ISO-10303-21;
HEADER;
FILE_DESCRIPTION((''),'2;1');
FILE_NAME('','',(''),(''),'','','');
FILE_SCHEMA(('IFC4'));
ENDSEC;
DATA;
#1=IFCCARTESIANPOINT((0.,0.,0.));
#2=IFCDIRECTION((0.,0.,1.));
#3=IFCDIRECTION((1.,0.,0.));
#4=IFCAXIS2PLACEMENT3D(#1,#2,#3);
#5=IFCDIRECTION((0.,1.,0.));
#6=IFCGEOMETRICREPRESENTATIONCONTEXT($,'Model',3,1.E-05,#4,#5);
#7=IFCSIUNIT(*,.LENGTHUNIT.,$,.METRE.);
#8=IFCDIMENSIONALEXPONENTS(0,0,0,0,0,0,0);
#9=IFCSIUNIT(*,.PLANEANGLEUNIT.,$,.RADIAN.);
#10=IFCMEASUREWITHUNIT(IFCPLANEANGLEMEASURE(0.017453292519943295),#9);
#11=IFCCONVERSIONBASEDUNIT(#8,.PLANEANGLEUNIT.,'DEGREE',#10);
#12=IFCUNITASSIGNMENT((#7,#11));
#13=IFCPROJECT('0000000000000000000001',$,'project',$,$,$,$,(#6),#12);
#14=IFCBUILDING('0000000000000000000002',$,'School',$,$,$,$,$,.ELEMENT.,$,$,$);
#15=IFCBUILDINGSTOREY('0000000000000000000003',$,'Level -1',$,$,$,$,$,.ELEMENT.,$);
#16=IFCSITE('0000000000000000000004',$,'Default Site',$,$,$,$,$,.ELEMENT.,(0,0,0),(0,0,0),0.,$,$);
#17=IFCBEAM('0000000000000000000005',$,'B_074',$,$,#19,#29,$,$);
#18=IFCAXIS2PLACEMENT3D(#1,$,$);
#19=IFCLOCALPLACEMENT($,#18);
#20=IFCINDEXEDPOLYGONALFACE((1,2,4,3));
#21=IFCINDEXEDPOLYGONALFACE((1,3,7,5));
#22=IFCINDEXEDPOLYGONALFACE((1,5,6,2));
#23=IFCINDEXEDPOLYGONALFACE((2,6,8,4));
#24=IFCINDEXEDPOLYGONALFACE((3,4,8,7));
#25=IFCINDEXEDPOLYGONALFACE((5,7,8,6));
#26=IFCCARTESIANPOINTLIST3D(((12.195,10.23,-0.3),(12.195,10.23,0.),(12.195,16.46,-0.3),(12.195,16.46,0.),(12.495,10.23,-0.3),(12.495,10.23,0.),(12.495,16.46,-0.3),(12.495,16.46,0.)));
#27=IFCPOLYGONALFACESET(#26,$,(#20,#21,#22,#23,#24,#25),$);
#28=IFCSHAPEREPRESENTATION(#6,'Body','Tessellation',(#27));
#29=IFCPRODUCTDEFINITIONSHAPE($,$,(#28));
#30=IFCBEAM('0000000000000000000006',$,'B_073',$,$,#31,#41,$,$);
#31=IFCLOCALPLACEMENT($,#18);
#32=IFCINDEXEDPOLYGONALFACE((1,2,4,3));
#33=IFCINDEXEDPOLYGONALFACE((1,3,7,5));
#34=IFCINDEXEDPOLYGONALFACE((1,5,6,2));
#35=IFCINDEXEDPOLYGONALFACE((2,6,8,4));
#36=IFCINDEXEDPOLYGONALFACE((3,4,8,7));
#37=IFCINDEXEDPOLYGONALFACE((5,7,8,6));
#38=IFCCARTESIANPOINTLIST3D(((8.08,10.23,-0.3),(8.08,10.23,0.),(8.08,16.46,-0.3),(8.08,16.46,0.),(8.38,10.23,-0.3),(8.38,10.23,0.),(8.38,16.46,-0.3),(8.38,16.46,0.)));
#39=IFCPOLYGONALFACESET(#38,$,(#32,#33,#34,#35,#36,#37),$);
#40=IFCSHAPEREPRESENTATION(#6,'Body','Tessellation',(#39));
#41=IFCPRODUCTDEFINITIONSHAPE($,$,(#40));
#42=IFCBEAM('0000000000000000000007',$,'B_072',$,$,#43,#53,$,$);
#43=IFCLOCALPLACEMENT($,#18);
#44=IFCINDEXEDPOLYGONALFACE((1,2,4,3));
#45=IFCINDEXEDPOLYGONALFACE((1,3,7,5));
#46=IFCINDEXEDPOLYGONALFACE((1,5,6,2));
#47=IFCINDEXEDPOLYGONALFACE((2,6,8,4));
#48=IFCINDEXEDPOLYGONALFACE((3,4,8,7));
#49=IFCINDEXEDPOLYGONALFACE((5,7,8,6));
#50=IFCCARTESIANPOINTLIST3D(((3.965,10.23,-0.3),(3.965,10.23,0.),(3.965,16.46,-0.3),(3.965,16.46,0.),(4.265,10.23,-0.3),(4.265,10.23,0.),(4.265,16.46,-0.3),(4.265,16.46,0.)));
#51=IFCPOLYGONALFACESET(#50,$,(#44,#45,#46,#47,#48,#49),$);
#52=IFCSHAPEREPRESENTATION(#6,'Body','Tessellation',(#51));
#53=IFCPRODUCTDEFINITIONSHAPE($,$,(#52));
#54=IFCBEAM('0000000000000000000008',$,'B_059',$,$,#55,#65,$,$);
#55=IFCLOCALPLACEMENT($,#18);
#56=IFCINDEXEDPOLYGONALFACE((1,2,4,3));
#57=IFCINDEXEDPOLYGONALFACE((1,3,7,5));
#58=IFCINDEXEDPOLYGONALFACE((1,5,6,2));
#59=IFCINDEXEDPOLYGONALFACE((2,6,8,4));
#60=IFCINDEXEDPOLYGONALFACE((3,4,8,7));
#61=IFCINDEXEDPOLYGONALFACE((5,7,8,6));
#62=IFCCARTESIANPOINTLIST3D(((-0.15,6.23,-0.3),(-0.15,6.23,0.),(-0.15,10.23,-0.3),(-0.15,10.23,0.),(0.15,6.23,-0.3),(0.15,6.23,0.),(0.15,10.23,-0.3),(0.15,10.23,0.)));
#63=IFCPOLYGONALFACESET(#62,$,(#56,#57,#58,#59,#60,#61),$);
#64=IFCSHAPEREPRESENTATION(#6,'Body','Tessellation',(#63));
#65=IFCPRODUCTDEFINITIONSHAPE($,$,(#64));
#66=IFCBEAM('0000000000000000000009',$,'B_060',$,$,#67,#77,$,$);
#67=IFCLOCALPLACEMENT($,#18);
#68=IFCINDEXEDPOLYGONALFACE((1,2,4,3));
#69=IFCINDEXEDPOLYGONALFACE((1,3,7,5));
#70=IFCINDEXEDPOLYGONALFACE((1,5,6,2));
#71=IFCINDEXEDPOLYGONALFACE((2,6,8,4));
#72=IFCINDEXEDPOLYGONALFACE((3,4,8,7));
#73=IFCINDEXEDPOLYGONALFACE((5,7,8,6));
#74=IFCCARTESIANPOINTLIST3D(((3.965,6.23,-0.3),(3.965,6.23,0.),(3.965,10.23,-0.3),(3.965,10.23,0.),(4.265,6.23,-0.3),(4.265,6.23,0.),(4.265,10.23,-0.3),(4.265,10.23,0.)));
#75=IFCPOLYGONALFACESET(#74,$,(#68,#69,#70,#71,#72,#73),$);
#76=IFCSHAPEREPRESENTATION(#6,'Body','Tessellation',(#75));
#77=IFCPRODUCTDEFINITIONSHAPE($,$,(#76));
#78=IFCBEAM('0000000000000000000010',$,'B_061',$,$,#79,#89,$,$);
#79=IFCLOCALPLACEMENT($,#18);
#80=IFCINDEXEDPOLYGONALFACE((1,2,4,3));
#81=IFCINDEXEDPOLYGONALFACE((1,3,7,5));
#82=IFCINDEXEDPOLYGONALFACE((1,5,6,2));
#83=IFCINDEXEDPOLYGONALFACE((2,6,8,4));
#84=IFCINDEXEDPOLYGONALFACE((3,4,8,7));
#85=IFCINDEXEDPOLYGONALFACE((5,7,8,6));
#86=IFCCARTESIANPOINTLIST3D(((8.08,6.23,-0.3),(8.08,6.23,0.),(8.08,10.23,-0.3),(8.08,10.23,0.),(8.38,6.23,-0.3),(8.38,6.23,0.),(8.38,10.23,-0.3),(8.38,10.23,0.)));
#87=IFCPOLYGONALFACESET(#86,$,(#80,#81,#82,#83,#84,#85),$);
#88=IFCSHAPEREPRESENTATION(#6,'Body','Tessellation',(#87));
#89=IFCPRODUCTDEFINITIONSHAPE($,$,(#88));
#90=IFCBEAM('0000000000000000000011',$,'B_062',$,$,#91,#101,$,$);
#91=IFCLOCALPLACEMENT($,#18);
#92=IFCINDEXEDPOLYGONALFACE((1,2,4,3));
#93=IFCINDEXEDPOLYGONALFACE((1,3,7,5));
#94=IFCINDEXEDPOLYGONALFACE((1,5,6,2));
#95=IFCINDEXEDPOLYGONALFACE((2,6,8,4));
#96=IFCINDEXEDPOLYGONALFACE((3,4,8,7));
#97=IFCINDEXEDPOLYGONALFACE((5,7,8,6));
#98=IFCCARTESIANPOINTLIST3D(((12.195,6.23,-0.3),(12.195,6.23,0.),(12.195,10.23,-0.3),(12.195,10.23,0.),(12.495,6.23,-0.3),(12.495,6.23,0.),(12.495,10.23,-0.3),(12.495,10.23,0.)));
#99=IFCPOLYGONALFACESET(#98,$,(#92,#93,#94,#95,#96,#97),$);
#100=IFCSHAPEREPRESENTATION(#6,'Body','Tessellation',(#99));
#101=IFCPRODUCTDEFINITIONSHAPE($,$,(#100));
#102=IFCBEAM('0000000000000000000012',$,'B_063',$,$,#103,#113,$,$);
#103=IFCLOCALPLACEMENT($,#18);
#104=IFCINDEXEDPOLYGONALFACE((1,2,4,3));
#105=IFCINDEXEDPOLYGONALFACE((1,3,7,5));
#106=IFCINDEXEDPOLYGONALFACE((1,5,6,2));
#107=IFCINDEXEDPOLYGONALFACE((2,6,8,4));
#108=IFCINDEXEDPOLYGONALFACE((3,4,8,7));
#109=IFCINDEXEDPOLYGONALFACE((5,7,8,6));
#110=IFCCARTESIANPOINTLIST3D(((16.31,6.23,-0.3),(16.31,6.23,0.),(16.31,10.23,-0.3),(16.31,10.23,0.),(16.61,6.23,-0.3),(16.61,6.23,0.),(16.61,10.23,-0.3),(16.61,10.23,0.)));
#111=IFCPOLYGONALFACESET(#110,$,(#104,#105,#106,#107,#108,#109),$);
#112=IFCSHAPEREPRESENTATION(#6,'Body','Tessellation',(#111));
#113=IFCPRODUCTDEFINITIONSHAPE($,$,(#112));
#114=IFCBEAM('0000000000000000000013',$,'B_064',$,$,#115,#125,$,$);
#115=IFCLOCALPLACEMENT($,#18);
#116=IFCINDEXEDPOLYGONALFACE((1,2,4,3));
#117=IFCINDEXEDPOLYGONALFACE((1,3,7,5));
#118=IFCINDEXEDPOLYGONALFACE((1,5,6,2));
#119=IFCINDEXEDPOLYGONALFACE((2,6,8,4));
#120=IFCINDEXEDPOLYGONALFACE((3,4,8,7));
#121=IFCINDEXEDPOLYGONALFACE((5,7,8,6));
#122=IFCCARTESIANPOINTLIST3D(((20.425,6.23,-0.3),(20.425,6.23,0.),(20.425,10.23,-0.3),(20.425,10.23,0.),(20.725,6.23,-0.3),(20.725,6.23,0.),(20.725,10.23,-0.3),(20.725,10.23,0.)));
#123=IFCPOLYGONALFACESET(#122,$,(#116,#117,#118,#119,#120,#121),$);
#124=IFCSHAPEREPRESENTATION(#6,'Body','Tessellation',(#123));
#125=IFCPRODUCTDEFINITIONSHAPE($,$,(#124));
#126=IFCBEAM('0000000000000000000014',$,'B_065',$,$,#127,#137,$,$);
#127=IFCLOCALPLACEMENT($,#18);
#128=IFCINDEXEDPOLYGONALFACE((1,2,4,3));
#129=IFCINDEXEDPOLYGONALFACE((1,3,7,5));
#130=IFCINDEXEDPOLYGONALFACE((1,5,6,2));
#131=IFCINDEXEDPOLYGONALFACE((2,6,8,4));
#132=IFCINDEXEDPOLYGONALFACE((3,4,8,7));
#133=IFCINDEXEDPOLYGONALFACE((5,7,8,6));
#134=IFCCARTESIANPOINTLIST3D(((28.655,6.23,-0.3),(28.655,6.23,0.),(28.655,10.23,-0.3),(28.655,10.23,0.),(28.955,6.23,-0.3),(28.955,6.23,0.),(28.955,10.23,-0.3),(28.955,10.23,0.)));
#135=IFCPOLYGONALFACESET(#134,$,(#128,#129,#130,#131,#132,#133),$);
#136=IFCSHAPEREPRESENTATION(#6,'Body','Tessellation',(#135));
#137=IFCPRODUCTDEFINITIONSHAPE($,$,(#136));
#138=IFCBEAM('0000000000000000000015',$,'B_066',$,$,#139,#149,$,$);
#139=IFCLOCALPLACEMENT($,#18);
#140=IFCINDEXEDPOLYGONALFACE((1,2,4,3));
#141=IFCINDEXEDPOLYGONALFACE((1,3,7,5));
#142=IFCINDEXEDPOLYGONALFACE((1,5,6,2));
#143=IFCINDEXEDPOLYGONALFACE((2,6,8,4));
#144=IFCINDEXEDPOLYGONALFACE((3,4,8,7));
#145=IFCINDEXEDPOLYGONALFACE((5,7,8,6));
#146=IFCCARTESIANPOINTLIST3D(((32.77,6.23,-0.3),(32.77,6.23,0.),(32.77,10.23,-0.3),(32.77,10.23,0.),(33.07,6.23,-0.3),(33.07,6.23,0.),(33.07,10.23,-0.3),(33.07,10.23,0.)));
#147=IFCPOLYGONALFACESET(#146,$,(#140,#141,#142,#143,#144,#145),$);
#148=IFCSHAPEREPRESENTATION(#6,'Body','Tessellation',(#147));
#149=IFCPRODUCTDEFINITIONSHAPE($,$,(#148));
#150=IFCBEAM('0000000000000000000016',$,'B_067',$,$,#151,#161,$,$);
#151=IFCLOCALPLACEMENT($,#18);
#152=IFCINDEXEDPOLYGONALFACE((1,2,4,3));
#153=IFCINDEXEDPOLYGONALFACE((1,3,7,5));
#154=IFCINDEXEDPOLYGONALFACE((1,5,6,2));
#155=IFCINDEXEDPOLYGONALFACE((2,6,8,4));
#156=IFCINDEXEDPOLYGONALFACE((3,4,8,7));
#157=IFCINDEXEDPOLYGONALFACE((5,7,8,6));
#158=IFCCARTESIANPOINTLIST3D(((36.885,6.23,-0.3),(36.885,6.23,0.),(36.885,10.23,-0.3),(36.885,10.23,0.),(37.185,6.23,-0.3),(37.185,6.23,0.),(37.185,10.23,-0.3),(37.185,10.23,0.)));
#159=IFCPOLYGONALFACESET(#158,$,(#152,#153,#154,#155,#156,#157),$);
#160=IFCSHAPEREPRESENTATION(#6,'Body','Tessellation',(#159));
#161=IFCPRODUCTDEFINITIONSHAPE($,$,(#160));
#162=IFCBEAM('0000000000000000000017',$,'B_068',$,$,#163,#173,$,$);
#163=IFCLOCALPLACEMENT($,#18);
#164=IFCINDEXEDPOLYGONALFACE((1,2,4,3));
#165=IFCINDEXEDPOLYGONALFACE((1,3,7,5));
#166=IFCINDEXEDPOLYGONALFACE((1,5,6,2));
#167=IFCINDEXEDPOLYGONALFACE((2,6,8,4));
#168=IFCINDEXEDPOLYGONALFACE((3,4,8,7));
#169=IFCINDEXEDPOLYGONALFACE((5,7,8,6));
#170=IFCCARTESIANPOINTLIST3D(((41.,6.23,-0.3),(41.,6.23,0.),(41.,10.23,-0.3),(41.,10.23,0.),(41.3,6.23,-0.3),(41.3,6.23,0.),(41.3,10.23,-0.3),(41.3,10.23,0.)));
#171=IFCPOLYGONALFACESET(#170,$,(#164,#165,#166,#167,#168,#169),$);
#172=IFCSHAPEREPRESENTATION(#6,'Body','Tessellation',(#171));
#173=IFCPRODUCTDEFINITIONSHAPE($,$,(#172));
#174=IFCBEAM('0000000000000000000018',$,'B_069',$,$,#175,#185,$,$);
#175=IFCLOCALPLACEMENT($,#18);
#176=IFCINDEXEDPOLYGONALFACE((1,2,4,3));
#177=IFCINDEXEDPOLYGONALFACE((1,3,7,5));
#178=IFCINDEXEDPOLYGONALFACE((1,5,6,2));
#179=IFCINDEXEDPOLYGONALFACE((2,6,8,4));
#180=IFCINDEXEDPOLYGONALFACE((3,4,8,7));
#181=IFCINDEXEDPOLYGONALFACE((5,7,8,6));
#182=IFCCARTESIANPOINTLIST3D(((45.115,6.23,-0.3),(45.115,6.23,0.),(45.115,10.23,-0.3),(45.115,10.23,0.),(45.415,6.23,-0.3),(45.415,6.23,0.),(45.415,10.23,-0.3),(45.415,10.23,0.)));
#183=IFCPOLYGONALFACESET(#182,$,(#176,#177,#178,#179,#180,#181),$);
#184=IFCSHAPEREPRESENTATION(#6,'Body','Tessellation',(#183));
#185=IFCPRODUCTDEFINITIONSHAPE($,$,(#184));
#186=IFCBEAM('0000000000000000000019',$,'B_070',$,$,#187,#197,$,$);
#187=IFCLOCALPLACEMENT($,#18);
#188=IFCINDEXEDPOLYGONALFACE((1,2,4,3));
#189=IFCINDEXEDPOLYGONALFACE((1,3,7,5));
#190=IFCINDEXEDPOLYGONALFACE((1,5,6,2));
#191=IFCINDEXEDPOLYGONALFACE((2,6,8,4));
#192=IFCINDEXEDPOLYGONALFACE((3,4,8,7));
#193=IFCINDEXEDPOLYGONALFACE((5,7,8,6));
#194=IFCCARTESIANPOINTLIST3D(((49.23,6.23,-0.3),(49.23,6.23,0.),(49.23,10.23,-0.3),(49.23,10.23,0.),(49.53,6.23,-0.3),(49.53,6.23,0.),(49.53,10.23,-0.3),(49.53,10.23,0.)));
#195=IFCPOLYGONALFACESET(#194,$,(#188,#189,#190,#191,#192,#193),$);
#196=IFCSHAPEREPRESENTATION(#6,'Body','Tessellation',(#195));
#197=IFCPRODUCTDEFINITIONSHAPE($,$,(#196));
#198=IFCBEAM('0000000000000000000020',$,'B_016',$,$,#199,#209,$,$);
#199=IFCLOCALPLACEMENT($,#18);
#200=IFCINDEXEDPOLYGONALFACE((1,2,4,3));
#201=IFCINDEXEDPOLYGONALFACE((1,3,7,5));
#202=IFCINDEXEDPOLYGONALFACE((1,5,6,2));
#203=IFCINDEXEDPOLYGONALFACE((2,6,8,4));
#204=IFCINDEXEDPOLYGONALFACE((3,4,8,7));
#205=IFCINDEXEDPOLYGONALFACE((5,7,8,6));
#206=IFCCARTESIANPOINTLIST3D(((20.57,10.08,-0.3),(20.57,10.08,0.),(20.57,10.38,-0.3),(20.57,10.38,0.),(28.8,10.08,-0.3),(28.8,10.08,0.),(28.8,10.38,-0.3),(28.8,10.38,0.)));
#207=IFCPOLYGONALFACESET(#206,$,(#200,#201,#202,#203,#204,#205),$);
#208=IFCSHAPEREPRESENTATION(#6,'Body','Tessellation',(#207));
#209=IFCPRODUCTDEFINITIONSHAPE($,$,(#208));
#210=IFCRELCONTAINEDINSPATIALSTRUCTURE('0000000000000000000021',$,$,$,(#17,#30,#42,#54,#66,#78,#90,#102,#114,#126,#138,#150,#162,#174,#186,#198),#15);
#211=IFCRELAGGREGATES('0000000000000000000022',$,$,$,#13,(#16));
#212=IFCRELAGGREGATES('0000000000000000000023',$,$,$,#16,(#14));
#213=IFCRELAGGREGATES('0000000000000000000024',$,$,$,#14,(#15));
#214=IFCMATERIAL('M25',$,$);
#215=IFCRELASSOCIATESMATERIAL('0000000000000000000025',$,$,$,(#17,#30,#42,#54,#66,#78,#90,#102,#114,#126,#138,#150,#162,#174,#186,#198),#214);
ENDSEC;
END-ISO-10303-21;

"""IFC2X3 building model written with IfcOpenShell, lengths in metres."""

from ifc_helpers import new_model, entity, si_unit, converted_unit, direction, frame, frame_2d, origin_with_axes, place, context, project, spatial, rectangle, extrude, material, element, save


model = new_model("IFC2X3")

# Units and contexts
model_context = context("Model", 3, precision=1e-05, world=origin_with_axes(), true_north=direction((0.0, 1.0, 0.0)))
ifc_project = project(units=[si_unit("LENGTHUNIT", "METRE"), converted_unit("PLANEANGLEUNIT", "DEGREE", entity("IfcPlaneAngleMeasure", 0.017453292519943295), si_unit("PLANEANGLEUNIT", "RADIAN"), dimensions=[0, 0, 0, 0, 0, 0, 0])], contexts=[model_context])

# Site, building, storey
site = spatial("IfcSite", under=ifc_project, Name="Default Site", CompositionType="ELEMENT", RefLatitude=(0, 0, 0), RefLongitude=(0, 0, 0), RefElevation=0.0)
building = spatial("IfcBuilding", under=site, Name="School", CompositionType="ELEMENT")
storey = spatial("IfcBuildingStorey", under=building, Name="Level -1", CompositionType="ELEMENT")

# Beams
ifc_material = material(Name="M25")
placement = place(None, origin_with_axes())
element("IfcBeam", 1, at=placement, inside=storey, material=ifc_material, Name="B_074", context=model_context, shape_type="SweptSolid", body=[
    extrude(rectangle(XDim=0.3, YDim=0.3, at=frame_2d((0.0, 0.0), x_axis=(0.0, 1.0, 0.0))), frame((12.345, 10.23, -0.15), z_axis=(0.0, 1.0, 0.0), x_axis=(0.0, 0.0, -1.0)), (0.0, 0.0, 1.0), 6.23),
])
element("IfcBeam", 2, at=placement, inside=storey, material=ifc_material, Name="B_073", context=model_context, shape_type="SweptSolid", body=[
    extrude(rectangle(XDim=0.3, YDim=0.3, at=frame_2d((0.0, 0.0), x_axis=(0.0, 1.0, 0.0))), frame((8.23, 10.23, -0.15), z_axis=(0.0, 1.0, 0.0), x_axis=(0.0, 0.0, -1.0)), (0.0, 0.0, 1.0), 6.23),
])
element("IfcBeam", 3, at=placement, inside=storey, material=ifc_material, Name="B_072", context=model_context, shape_type="SweptSolid", body=[
    extrude(rectangle(XDim=0.3, YDim=0.3, at=frame_2d((0.0, 0.0), x_axis=(0.0, 1.0, 0.0))), frame((4.115, 10.23, -0.15), z_axis=(0.0, 1.0, 0.0), x_axis=(0.0, 0.0, -1.0)), (0.0, 0.0, 1.0), 6.23),
])
element("IfcBeam", 4, at=placement, inside=storey, material=ifc_material, Name="B_059", context=model_context, shape_type="SweptSolid", body=[
    extrude(rectangle(XDim=0.3, YDim=0.3, at=frame_2d((0.0, 0.0), x_axis=(0.0, 1.0, 0.0))), frame((0.0, 6.23, -0.15), z_axis=(0.0, 1.0, 0.0), x_axis=(0.0, 0.0, -1.0)), (0.0, 0.0, 1.0), 4.0),
])
element("IfcBeam", 5, at=placement, inside=storey, material=ifc_material, Name="B_060", context=model_context, shape_type="SweptSolid", body=[
    extrude(rectangle(XDim=0.3, YDim=0.3, at=frame_2d((0.0, 0.0), x_axis=(0.0, 1.0, 0.0))), frame((4.115, 6.23, -0.15), z_axis=(0.0, 1.0, 0.0), x_axis=(0.0, 0.0, -1.0)), (0.0, 0.0, 1.0), 4.0),
])
element("IfcBeam", 6, at=placement, inside=storey, material=ifc_material, Name="B_061", context=model_context, shape_type="SweptSolid", body=[
    extrude(rectangle(XDim=0.3, YDim=0.3, at=frame_2d((0.0, 0.0), x_axis=(0.0, 1.0, 0.0))), frame((8.23, 6.23, -0.15), z_axis=(0.0, 1.0, 0.0), x_axis=(0.0, 0.0, -1.0)), (0.0, 0.0, 1.0), 4.0),
])
element("IfcBeam", 7, at=placement, inside=storey, material=ifc_material, Name="B_062", context=model_context, shape_type="SweptSolid", body=[
    extrude(rectangle(XDim=0.3, YDim=0.3, at=frame_2d((0.0, 0.0), x_axis=(0.0, 1.0, 0.0))), frame((12.345, 6.23, -0.15), z_axis=(0.0, 1.0, 0.0), x_axis=(0.0, 0.0, -1.0)), (0.0, 0.0, 1.0), 4.0),
])
element("IfcBeam", 8, at=placement, inside=storey, material=ifc_material, Name="B_063", context=model_context, shape_type="SweptSolid", body=[
    extrude(rectangle(XDim=0.3, YDim=0.3, at=frame_2d((0.0, 0.0), x_axis=(0.0, 1.0, 0.0))), frame((16.46, 6.23, -0.15), z_axis=(0.0, 1.0, 0.0), x_axis=(0.0, 0.0, -1.0)), (0.0, 0.0, 1.0), 4.0),
])
element("IfcBeam", 9, at=placement, inside=storey, material=ifc_material, Name="B_064", context=model_context, shape_type="SweptSolid", body=[
    extrude(rectangle(XDim=0.3, YDim=0.3, at=frame_2d((0.0, 0.0), x_axis=(0.0, 1.0, 0.0))), frame((20.575, 6.23, -0.15), z_axis=(0.0, 1.0, 0.0), x_axis=(0.0, 0.0, -1.0)), (0.0, 0.0, 1.0), 4.0),
])
element("IfcBeam", 10, at=placement, inside=storey, material=ifc_material, Name="B_065", context=model_context, shape_type="SweptSolid", body=[
    extrude(rectangle(XDim=0.3, YDim=0.3, at=frame_2d((0.0, 0.0), x_axis=(0.0, 1.0, 0.0))), frame((28.805, 6.23, -0.15), z_axis=(0.0, 1.0, 0.0), x_axis=(0.0, 0.0, -1.0)), (0.0, 0.0, 1.0), 4.0),
])
element("IfcBeam", 11, at=placement, inside=storey, material=ifc_material, Name="B_066", context=model_context, shape_type="SweptSolid", body=[
    extrude(rectangle(XDim=0.3, YDim=0.3, at=frame_2d((0.0, 0.0), x_axis=(0.0, 1.0, 0.0))), frame((32.92, 6.23, -0.15), z_axis=(0.0, 1.0, 0.0), x_axis=(0.0, 0.0, -1.0)), (0.0, 0.0, 1.0), 4.0),
])
element("IfcBeam", 12, at=placement, inside=storey, material=ifc_material, Name="B_067", context=model_context, shape_type="SweptSolid", body=[
    extrude(rectangle(XDim=0.3, YDim=0.3, at=frame_2d((0.0, 0.0), x_axis=(0.0, 1.0, 0.0))), frame((37.035, 6.23, -0.15), z_axis=(0.0, 1.0, 0.0), x_axis=(0.0, 0.0, -1.0)), (0.0, 0.0, 1.0), 4.0),
])
element("IfcBeam", 13, at=placement, inside=storey, material=ifc_material, Name="B_068", context=model_context, shape_type="SweptSolid", body=[
    extrude(rectangle(XDim=0.3, YDim=0.3, at=frame_2d((0.0, 0.0), x_axis=(0.0, 1.0, 0.0))), frame((41.15, 6.23, -0.15), z_axis=(0.0, 1.0, 0.0), x_axis=(0.0, 0.0, -1.0)), (0.0, 0.0, 1.0), 4.0),
])
element("IfcBeam", 14, at=placement, inside=storey, material=ifc_material, Name="B_069", context=model_context, shape_type="SweptSolid", body=[
    extrude(rectangle(XDim=0.3, YDim=0.3, at=frame_2d((0.0, 0.0), x_axis=(0.0, 1.0, 0.0))), frame((45.265, 6.23, -0.15), z_axis=(0.0, 1.0, 0.0), x_axis=(0.0, 0.0, -1.0)), (0.0, 0.0, 1.0), 4.0),
])
element("IfcBeam", 15, at=placement, inside=storey, material=ifc_material, Name="B_070", context=model_context, shape_type="SweptSolid", body=[
    extrude(rectangle(XDim=0.3, YDim=0.3, at=frame_2d((0.0, 0.0), x_axis=(0.0, 1.0, 0.0))), frame((49.38, 6.23, -0.15), z_axis=(0.0, 1.0, 0.0), x_axis=(0.0, 0.0, -1.0)), (0.0, 0.0, 1.0), 4.0),
])
element("IfcBeam", 16, at=placement, inside=storey, material=ifc_material, Name="B_016", context=model_context, shape_type="SweptSolid", body=[
    extrude(rectangle(XDim=0.3, YDim=0.3, at=frame_2d((0.0, 0.0), x_axis=(0.0, 1.0, 0.0))), frame((20.57, 10.23, -0.15), z_axis=(1.0, 0.0, 0.0), x_axis=(0.0, 0.0, -1.0)), (0.0, 0.0, 1.0), 8.23),
])

save(model, "model.ifc")
